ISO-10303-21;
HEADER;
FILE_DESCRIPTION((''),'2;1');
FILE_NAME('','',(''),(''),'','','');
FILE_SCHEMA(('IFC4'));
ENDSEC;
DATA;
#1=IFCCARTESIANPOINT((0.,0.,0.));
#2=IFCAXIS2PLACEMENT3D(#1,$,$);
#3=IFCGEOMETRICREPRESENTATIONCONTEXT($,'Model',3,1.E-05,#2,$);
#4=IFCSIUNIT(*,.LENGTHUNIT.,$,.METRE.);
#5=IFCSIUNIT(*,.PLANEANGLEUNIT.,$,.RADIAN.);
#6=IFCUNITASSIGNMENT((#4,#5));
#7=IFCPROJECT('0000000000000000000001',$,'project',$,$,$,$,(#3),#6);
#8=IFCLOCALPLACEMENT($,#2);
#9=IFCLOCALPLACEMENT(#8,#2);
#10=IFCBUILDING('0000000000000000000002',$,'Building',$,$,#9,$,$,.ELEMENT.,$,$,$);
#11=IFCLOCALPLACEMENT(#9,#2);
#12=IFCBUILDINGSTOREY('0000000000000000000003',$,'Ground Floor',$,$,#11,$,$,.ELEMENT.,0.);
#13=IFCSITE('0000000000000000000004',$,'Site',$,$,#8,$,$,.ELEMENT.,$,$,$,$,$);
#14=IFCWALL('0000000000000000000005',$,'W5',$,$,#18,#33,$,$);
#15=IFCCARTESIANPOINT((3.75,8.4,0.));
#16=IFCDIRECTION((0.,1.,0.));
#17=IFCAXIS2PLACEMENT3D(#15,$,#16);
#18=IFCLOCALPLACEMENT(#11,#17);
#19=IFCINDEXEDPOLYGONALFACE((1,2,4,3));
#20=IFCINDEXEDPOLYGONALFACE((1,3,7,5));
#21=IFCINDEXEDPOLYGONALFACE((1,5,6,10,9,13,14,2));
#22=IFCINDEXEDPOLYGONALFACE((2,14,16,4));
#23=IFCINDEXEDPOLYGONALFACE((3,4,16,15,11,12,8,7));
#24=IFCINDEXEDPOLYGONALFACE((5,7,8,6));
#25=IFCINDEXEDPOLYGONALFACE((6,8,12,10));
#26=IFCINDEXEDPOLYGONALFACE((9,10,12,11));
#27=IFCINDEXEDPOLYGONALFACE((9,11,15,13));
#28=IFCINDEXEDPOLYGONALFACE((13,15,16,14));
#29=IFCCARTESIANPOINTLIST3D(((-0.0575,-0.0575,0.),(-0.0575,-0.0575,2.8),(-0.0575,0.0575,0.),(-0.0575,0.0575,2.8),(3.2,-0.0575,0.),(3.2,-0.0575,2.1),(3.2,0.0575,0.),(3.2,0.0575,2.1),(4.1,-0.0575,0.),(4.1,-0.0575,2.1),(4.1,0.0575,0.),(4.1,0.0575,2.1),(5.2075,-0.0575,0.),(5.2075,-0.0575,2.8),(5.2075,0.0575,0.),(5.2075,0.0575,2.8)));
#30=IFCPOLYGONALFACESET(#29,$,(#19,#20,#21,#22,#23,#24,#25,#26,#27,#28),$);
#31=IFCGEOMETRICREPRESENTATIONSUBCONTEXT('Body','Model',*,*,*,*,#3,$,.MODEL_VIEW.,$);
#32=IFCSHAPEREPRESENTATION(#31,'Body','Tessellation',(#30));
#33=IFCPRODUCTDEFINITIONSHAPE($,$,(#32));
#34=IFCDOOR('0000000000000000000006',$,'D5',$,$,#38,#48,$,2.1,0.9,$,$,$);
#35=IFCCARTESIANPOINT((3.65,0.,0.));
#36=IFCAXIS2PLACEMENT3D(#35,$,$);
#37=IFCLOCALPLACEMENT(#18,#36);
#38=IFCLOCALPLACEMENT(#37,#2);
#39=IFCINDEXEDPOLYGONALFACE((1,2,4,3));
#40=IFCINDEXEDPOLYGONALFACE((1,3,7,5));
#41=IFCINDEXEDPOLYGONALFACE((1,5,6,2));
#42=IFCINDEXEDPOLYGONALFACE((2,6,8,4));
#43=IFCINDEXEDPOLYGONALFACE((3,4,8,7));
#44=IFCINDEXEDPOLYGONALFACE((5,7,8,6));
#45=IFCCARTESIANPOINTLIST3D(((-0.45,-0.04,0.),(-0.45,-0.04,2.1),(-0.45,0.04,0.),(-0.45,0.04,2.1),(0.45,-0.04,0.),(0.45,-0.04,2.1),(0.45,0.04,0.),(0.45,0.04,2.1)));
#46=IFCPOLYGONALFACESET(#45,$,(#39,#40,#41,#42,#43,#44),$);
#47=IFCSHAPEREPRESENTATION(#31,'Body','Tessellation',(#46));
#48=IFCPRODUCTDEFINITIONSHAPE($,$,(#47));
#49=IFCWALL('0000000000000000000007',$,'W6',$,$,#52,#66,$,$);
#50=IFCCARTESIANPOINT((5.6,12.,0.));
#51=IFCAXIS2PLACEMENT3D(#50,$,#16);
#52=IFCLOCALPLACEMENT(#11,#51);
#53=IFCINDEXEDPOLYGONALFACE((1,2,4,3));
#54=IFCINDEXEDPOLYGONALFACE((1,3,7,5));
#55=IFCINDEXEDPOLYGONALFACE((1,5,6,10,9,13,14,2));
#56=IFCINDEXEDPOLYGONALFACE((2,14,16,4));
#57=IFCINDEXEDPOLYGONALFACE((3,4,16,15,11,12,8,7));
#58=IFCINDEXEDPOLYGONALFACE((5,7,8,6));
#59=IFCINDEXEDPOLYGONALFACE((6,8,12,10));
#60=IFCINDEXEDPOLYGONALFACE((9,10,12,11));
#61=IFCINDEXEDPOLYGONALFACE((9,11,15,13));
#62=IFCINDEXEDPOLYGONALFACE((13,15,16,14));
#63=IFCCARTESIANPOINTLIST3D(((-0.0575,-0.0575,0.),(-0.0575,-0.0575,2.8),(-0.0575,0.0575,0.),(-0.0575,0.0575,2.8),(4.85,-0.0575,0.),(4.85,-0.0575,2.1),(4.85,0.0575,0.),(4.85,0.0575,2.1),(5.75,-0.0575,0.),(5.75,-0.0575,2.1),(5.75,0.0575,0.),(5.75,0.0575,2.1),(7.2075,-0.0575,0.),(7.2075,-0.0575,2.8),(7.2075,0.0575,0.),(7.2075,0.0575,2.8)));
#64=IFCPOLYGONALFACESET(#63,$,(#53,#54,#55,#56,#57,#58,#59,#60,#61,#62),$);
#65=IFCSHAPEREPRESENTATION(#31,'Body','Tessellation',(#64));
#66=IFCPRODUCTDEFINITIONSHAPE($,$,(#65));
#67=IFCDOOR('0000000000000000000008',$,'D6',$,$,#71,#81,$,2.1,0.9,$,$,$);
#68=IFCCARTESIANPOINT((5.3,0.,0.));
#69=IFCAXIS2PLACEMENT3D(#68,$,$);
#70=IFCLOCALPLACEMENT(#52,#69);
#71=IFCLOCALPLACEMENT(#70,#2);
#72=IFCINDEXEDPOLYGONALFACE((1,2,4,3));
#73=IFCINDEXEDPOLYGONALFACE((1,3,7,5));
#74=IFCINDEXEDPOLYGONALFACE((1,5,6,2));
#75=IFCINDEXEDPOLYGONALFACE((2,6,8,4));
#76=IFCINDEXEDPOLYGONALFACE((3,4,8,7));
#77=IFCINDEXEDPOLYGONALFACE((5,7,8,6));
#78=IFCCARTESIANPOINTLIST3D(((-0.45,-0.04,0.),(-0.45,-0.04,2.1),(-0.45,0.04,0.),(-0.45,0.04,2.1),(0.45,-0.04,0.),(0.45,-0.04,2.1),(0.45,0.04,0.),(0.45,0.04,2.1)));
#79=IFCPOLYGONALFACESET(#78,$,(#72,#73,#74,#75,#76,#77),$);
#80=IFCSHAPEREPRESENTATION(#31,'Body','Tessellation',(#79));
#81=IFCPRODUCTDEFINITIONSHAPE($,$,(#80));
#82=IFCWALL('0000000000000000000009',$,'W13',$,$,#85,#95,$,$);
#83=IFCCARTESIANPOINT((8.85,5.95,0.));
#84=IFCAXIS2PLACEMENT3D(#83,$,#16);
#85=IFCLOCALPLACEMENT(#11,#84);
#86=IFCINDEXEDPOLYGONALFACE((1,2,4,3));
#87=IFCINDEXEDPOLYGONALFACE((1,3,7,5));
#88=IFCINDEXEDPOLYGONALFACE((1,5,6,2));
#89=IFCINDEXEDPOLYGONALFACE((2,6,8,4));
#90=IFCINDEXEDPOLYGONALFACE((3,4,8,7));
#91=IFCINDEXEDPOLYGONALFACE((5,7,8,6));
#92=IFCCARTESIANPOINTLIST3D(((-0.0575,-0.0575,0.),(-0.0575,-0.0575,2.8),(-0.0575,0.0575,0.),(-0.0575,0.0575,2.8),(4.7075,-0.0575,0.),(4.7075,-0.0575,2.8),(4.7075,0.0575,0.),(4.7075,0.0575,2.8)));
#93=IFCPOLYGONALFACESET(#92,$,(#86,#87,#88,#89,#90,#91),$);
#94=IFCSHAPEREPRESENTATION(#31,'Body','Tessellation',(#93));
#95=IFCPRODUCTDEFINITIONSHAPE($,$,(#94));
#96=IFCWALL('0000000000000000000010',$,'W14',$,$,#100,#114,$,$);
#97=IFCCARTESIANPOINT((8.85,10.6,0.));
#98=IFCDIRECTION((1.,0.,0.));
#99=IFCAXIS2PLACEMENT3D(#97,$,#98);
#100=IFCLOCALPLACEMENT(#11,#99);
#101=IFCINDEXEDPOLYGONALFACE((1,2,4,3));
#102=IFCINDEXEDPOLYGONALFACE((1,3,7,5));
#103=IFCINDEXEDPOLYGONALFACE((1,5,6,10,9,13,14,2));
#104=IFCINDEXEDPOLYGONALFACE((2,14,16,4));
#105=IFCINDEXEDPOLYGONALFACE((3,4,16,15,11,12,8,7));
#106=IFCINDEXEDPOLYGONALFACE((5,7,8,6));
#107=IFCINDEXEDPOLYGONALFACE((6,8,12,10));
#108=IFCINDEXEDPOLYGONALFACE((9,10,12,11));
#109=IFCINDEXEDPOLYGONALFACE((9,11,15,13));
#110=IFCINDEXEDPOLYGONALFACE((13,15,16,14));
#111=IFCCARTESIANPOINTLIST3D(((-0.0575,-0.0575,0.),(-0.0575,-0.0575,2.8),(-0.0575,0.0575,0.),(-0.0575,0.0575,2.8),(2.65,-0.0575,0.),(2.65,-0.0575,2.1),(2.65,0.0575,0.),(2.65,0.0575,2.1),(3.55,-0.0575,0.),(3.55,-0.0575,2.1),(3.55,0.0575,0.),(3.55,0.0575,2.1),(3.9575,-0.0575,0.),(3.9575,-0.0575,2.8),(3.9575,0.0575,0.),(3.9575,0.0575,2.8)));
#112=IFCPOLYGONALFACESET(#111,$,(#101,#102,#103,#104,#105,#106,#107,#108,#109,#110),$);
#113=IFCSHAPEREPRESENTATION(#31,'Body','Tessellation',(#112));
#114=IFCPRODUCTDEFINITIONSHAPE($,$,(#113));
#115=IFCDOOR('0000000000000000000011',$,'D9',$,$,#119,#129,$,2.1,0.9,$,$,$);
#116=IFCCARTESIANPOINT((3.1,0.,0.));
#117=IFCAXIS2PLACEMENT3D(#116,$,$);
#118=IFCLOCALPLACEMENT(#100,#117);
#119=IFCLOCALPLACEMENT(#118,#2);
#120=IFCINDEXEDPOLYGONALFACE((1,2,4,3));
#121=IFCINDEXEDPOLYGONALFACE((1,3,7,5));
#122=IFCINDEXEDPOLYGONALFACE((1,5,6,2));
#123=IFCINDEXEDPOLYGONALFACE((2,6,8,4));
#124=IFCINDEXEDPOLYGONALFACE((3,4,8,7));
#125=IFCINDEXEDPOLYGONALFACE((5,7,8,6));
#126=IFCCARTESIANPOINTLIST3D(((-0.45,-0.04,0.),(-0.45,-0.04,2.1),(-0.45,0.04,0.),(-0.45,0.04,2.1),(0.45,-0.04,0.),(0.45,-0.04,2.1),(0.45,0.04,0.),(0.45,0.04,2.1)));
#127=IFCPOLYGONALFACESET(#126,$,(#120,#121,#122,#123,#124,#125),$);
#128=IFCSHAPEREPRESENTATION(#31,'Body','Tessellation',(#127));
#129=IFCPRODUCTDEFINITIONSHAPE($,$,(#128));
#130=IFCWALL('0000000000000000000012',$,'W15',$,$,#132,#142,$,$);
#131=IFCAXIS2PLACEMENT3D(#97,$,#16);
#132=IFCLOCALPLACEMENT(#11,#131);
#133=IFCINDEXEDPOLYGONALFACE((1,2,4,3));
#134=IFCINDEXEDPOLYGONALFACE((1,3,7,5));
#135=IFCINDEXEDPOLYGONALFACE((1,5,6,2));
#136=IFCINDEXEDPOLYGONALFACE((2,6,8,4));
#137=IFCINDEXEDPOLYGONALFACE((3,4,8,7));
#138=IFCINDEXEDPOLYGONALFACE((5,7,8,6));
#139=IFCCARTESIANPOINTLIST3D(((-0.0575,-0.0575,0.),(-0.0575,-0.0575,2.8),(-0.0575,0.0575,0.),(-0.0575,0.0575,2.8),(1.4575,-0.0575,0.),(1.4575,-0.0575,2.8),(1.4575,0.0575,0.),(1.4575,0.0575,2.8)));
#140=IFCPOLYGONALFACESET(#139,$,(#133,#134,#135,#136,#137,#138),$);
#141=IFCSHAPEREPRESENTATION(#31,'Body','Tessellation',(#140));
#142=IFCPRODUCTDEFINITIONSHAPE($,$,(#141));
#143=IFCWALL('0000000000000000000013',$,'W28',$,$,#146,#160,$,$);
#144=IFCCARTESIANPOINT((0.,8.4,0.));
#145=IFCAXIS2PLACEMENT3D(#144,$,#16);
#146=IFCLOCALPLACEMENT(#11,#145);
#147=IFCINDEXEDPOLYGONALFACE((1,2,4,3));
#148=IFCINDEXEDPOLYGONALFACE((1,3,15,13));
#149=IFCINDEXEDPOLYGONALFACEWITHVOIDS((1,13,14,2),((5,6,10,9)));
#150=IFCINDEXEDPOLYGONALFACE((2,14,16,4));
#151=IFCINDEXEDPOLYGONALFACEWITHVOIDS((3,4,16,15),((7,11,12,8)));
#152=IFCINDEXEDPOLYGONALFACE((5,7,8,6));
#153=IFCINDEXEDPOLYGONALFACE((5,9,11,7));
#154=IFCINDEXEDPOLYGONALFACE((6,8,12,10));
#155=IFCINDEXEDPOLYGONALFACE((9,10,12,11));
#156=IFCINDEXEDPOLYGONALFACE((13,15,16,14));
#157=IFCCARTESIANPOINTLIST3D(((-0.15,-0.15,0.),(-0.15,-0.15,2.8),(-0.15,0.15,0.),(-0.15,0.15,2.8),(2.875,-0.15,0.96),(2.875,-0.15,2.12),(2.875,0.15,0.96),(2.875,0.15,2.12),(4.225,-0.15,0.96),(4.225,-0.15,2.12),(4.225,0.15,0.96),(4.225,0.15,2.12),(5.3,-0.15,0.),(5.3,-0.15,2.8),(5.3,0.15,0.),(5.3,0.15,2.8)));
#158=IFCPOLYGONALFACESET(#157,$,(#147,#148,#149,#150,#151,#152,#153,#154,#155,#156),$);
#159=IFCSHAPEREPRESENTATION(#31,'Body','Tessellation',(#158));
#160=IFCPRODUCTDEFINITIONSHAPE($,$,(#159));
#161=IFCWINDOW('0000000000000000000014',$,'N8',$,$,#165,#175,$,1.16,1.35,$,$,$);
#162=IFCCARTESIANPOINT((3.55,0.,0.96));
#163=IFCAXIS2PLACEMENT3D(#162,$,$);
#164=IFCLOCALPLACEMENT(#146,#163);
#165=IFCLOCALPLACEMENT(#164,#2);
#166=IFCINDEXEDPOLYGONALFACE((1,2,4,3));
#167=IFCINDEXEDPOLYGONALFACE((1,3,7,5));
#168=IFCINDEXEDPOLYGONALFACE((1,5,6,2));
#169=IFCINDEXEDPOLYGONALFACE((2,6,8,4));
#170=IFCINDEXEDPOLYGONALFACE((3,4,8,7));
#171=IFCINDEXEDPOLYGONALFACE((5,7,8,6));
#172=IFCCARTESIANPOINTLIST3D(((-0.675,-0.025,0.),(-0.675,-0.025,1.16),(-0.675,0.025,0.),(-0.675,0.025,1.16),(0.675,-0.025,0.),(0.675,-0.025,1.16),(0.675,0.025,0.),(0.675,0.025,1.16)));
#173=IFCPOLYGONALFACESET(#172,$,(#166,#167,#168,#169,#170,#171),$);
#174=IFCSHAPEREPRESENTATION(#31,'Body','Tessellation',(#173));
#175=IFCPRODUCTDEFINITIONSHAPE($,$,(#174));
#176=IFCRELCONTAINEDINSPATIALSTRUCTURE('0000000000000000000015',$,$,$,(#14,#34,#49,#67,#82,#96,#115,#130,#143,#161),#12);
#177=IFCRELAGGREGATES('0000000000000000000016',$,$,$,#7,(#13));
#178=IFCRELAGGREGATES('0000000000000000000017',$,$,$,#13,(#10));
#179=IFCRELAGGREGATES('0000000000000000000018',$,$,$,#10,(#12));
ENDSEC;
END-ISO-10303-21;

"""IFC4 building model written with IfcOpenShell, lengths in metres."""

from ifc_helpers import new_model, si_unit, frame, frame_2d, origin, origin_2d, place, context, subcontext, project, spatial, rectangle, extrude, element, fill, save


model = new_model("IFC4")

# Units and contexts
model_context = context("Model", 3, precision=1e-05, world=origin())
body_context = subcontext(model_context, "Body", "Model", "MODEL_VIEW")
ifc_project = project(units=[si_unit("LENGTHUNIT", "METRE"), si_unit("PLANEANGLEUNIT", "RADIAN")], contexts=[model_context])

# Site, building, storey
site_placement = place(None, origin())
site = spatial("IfcSite", under=ifc_project, at=site_placement, Name="Site", CompositionType="ELEMENT")
building_placement = place(site_placement, origin())
building = spatial("IfcBuilding", under=site, at=building_placement, Name="Building", CompositionType="ELEMENT")
storey_placement = place(building_placement, origin())
storey = spatial("IfcBuildingStorey", under=building, at=storey_placement, Name="Ground Floor", CompositionType="ELEMENT", Elevation=0.0)

# Walls, openings, doors
wall_1_placement = place(storey_placement, frame((3.75, 8.4, 0.0), x_axis=(0.0, 1.0, 0.0)))
wall_1 = element("IfcWall", 1, at=wall_1_placement, inside=storey, Name="W5", context=body_context, shape_type="SweptSolid", body=[
    extrude(rectangle(XDim=5.265, YDim=0.115, at=frame_2d((2.575, 0.0))), origin(), (0.0, 0.0, 1.0), 2.8),
])
opening_1_placement = place(wall_1_placement, frame((3.65, 0.0, 0.0)))
opening_1 = element("IfcOpeningElement", 2, at=opening_1_placement, cuts=wall_1, context=body_context, shape_type="SweptSolid", body=[
    extrude(rectangle(XDim=0.9, YDim=0.215, at=origin_2d()), origin(), (0.0, 0.0, 1.0), 2.1),
])
door_1_placement = place(opening_1_placement, origin())
door_1 = element("IfcDoor", 3, at=door_1_placement, inside=storey, Name="D5", OverallHeight=2.1, OverallWidth=0.9, context=body_context, shape_type="SweptSolid", body=[
    extrude(rectangle(XDim=0.9, YDim=0.08, at=origin_2d()), origin(), (0.0, 0.0, 1.0), 2.1),
])
fill(opening_1, door_1)
wall_2_placement = place(storey_placement, frame((5.6, 12.0, 0.0), x_axis=(0.0, 1.0, 0.0)))
wall_2 = element("IfcWall", 4, at=wall_2_placement, inside=storey, Name="W6", context=body_context, shape_type="SweptSolid", body=[
    extrude(rectangle(XDim=7.265, YDim=0.115, at=frame_2d((3.575, 0.0))), origin(), (0.0, 0.0, 1.0), 2.8),
])
opening_2_placement = place(wall_2_placement, frame((5.3, 0.0, 0.0)))
opening_2 = element("IfcOpeningElement", 5, at=opening_2_placement, cuts=wall_2, context=body_context, shape_type="SweptSolid", body=[
    extrude(rectangle(XDim=0.9, YDim=0.215, at=origin_2d()), origin(), (0.0, 0.0, 1.0), 2.1),
])
door_2_placement = place(opening_2_placement, origin())
door_2 = element("IfcDoor", 6, at=door_2_placement, inside=storey, Name="D6", OverallHeight=2.1, OverallWidth=0.9, context=body_context, shape_type="SweptSolid", body=[
    extrude(rectangle(XDim=0.9, YDim=0.08, at=origin_2d()), origin(), (0.0, 0.0, 1.0), 2.1),
])
fill(opening_2, door_2)

# Wall
wall_3_placement = place(storey_placement, frame((8.85, 5.95, 0.0), x_axis=(0.0, 1.0, 0.0)))
element("IfcWall", 7, at=wall_3_placement, inside=storey, Name="W13", context=body_context, shape_type="SweptSolid", body=[
    extrude(rectangle(XDim=4.765, YDim=0.115, at=frame_2d((2.325, 0.0))), origin(), (0.0, 0.0, 1.0), 2.8),
])

# Wall, opening, door
wall_4_placement = place(storey_placement, frame((8.85, 10.6, 0.0), x_axis=(1.0, 0.0, 0.0)))
wall_4 = element("IfcWall", 8, at=wall_4_placement, inside=storey, Name="W14", context=body_context, shape_type="SweptSolid", body=[
    extrude(rectangle(XDim=4.015, YDim=0.115, at=frame_2d((1.95, 0.0))), origin(), (0.0, 0.0, 1.0), 2.8),
])
opening_3_placement = place(wall_4_placement, frame((3.1, 0.0, 0.0)))
opening_3 = element("IfcOpeningElement", 9, at=opening_3_placement, cuts=wall_4, context=body_context, shape_type="SweptSolid", body=[
    extrude(rectangle(XDim=0.9, YDim=0.215, at=origin_2d()), origin(), (0.0, 0.0, 1.0), 2.1),
])
door_3_placement = place(opening_3_placement, origin())
door_3 = element("IfcDoor", 10, at=door_3_placement, inside=storey, Name="D9", OverallHeight=2.1, OverallWidth=0.9, context=body_context, shape_type="SweptSolid", body=[
    extrude(rectangle(XDim=0.9, YDim=0.08, at=origin_2d()), origin(), (0.0, 0.0, 1.0), 2.1),
])
fill(opening_3, door_3)

# Wall
wall_5_placement = place(storey_placement, frame((8.85, 10.6, 0.0), x_axis=(0.0, 1.0, 0.0)))
element("IfcWall", 11, at=wall_5_placement, inside=storey, Name="W15", context=body_context, shape_type="SweptSolid", body=[
    extrude(rectangle(XDim=1.515, YDim=0.115, at=frame_2d((0.7, 0.0))), origin(), (0.0, 0.0, 1.0), 2.8),
])

# Wall, opening, window
wall_6_placement = place(storey_placement, frame((0.0, 8.4, 0.0), x_axis=(0.0, 1.0, 0.0)))
wall_6 = element("IfcWall", 12, at=wall_6_placement, inside=storey, Name="W28", context=body_context, shape_type="SweptSolid", body=[
    extrude(rectangle(XDim=5.45, YDim=0.3, at=frame_2d((2.575, 0.0))), origin(), (0.0, 0.0, 1.0), 2.8),
])
opening_4_placement = place(wall_6_placement, frame((3.55, 0.0, 0.96)))
opening_4 = element("IfcOpeningElement", 13, at=opening_4_placement, cuts=wall_6, context=body_context, shape_type="SweptSolid", body=[
    extrude(rectangle(XDim=1.35, YDim=0.4, at=origin_2d()), origin(), (0.0, 0.0, 1.0), 1.16),
])
window_1_placement = place(opening_4_placement, origin())
window_1 = element("IfcWindow", 14, at=window_1_placement, inside=storey, Name="N8", OverallHeight=1.16, OverallWidth=1.35, context=body_context, shape_type="SweptSolid", body=[
    extrude(rectangle(XDim=1.35, YDim=0.05, at=origin_2d()), origin(), (0.0, 0.0, 1.0), 1.16),
])
fill(opening_4, window_1)

save(model, "model.ifc")
